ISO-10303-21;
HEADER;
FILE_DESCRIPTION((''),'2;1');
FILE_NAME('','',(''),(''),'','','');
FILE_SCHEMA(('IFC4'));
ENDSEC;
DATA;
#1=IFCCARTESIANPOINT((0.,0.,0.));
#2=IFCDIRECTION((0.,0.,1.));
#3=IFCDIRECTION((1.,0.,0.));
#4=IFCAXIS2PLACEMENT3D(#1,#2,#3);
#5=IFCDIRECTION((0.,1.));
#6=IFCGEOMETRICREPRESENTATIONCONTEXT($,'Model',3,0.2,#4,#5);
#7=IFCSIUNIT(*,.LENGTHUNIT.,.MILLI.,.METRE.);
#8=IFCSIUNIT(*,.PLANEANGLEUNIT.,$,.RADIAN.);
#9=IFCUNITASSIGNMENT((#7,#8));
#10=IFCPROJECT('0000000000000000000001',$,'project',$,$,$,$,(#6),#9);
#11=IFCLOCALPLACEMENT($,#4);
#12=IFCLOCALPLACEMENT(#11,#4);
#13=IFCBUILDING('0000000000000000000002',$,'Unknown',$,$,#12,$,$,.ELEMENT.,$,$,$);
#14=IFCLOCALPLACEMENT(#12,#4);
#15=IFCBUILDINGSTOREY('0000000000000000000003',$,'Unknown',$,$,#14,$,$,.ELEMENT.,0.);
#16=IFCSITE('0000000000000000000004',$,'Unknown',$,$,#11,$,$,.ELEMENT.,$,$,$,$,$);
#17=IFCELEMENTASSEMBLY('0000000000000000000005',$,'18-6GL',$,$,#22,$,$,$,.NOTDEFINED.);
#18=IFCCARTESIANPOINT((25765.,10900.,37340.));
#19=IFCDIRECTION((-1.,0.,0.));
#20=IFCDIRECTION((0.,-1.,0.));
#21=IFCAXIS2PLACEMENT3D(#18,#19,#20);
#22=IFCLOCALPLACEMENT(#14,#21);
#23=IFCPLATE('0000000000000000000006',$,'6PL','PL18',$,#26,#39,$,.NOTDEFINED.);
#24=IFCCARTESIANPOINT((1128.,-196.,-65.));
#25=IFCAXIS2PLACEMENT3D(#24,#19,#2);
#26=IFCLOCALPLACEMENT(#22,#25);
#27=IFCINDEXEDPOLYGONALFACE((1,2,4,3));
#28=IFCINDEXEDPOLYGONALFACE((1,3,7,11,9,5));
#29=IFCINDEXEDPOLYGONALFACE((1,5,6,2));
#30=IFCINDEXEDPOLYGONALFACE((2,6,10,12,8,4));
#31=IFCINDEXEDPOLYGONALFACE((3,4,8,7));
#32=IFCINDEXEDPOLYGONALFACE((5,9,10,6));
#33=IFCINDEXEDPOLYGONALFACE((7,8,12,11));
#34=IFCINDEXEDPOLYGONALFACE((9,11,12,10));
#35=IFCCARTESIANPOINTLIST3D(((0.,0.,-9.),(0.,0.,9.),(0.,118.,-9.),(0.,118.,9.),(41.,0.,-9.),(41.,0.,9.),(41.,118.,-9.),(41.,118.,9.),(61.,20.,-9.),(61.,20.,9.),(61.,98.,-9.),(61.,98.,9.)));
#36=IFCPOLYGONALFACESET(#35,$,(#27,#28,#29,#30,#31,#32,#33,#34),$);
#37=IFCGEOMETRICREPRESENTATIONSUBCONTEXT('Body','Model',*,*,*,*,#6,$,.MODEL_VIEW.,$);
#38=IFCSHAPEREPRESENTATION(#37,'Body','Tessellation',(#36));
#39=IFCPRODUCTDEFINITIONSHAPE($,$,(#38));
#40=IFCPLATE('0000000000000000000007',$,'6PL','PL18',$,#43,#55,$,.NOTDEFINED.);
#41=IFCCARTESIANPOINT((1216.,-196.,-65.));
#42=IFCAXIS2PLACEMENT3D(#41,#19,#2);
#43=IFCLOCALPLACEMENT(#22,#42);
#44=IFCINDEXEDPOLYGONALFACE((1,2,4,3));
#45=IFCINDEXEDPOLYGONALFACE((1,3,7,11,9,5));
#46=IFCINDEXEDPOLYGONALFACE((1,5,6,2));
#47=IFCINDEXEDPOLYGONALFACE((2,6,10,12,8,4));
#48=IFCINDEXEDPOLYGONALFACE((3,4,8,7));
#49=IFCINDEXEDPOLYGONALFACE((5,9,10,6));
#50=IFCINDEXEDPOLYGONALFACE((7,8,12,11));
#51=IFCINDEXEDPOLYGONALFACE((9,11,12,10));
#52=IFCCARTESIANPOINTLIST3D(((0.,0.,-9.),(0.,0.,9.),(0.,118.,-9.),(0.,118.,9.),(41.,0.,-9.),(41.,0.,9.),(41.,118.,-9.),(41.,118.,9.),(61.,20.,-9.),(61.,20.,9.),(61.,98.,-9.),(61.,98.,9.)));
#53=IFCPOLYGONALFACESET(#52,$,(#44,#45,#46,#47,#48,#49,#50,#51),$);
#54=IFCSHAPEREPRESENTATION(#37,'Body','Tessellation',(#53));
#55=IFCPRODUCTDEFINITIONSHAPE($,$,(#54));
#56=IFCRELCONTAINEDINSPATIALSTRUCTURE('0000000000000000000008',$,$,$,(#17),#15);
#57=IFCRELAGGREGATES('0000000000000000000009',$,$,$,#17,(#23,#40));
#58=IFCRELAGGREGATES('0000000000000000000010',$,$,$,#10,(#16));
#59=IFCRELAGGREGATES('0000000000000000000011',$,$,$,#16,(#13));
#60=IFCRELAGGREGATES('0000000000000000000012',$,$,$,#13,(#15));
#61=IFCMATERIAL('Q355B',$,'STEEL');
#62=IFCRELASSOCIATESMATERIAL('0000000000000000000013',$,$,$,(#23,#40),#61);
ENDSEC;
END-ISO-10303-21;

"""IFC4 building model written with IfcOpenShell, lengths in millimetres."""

from ifc_helpers import new_model, si_unit, direction, frame, origin_with_axes, place, context, subcontext, project, spatial, line, indexed_curve, outline, extrude, material, element, aggregate, save


model = new_model("IFC4")

# Units and contexts
model_context = context("Model", 3, precision=0.2, world=origin_with_axes(), true_north=direction((0.0, 1.0)))
body_context = subcontext(model_context, "Body", "Model", "MODEL_VIEW")
ifc_project = project(units=[si_unit("LENGTHUNIT", "METRE", prefix="MILLI"), si_unit("PLANEANGLEUNIT", "RADIAN")], contexts=[model_context])

# Site, building, storey
site_placement = place(None, origin_with_axes())
site = spatial("IfcSite", under=ifc_project, at=site_placement, Name="Unknown", CompositionType="ELEMENT")
building_placement = place(site_placement, origin_with_axes())
building = spatial("IfcBuilding", under=site, at=building_placement, Name="Unknown", CompositionType="ELEMENT")
storey_placement = place(building_placement, origin_with_axes())
storey = spatial("IfcBuildingStorey", under=building, at=storey_placement, Name="Unknown", CompositionType="ELEMENT", Elevation=0.0)

# Shared definitions
ifc_material_1 = material(Name="Q355B", Category="STEEL")

# Element assembly, plates
assembly_1_placement = place(storey_placement, frame((25765.0, 10900.0, 37340.0), z_axis=(-1.0, 0.0, 0.0), x_axis=(0.0, -1.0, 0.0)))
assembly_1 = element("IfcElementAssembly", 1, at=assembly_1_placement, inside=storey, Name="18-6GL", PredefinedType="NOTDEFINED")
plate_1_placement = place(assembly_1_placement, frame((1128.0, -196.0, -65.0), z_axis=(-1.0, 0.0, 0.0), x_axis=(0.0, 0.0, 1.0)))
plate_1 = element("IfcPlate", 2, at=plate_1_placement, material=ifc_material_1, Name="6PL", Description="PL18", PredefinedType="NOTDEFINED", context=body_context, shape_type="SolidModel", body=[
    extrude(outline(indexed_curve([(0.0, 0.0), (41.0, 0.0), (61.0, 20.0), (61.0, 98.0), (41.0, 118.0), (0.0, 118.0)], segments=[line(1, 2, 3, 4, 5, 6, 1)])), frame((0.0, 0.0, 9.0), z_axis=(0.0, 0.0, 1.0), x_axis=(1.0, 0.0, 0.0)), (0.0, 0.0, -1.0), 18.0),
])
plate_2_placement = place(assembly_1_placement, frame((1216.0, -196.0, -65.0), z_axis=(-1.0, 0.0, 0.0), x_axis=(0.0, 0.0, 1.0)))
plate_2 = element("IfcPlate", 3, at=plate_2_placement, material=ifc_material_1, Name="6PL", Description="PL18", PredefinedType="NOTDEFINED", context=body_context, shape_type="SolidModel", body=[
    extrude(outline(indexed_curve([(0.0, 0.0), (41.0, 0.0), (61.0, 20.0), (61.0, 98.0), (41.0, 118.0), (0.0, 118.0)], segments=[line(1, 2, 3, 4, 5, 6, 1)])), frame((0.0, 0.0, 9.0), z_axis=(0.0, 0.0, 1.0), x_axis=(1.0, 0.0, 0.0)), (0.0, 0.0, -1.0), 18.0),
])
aggregate(assembly_1, [plate_1, plate_2])

save(model, "model.ifc")
